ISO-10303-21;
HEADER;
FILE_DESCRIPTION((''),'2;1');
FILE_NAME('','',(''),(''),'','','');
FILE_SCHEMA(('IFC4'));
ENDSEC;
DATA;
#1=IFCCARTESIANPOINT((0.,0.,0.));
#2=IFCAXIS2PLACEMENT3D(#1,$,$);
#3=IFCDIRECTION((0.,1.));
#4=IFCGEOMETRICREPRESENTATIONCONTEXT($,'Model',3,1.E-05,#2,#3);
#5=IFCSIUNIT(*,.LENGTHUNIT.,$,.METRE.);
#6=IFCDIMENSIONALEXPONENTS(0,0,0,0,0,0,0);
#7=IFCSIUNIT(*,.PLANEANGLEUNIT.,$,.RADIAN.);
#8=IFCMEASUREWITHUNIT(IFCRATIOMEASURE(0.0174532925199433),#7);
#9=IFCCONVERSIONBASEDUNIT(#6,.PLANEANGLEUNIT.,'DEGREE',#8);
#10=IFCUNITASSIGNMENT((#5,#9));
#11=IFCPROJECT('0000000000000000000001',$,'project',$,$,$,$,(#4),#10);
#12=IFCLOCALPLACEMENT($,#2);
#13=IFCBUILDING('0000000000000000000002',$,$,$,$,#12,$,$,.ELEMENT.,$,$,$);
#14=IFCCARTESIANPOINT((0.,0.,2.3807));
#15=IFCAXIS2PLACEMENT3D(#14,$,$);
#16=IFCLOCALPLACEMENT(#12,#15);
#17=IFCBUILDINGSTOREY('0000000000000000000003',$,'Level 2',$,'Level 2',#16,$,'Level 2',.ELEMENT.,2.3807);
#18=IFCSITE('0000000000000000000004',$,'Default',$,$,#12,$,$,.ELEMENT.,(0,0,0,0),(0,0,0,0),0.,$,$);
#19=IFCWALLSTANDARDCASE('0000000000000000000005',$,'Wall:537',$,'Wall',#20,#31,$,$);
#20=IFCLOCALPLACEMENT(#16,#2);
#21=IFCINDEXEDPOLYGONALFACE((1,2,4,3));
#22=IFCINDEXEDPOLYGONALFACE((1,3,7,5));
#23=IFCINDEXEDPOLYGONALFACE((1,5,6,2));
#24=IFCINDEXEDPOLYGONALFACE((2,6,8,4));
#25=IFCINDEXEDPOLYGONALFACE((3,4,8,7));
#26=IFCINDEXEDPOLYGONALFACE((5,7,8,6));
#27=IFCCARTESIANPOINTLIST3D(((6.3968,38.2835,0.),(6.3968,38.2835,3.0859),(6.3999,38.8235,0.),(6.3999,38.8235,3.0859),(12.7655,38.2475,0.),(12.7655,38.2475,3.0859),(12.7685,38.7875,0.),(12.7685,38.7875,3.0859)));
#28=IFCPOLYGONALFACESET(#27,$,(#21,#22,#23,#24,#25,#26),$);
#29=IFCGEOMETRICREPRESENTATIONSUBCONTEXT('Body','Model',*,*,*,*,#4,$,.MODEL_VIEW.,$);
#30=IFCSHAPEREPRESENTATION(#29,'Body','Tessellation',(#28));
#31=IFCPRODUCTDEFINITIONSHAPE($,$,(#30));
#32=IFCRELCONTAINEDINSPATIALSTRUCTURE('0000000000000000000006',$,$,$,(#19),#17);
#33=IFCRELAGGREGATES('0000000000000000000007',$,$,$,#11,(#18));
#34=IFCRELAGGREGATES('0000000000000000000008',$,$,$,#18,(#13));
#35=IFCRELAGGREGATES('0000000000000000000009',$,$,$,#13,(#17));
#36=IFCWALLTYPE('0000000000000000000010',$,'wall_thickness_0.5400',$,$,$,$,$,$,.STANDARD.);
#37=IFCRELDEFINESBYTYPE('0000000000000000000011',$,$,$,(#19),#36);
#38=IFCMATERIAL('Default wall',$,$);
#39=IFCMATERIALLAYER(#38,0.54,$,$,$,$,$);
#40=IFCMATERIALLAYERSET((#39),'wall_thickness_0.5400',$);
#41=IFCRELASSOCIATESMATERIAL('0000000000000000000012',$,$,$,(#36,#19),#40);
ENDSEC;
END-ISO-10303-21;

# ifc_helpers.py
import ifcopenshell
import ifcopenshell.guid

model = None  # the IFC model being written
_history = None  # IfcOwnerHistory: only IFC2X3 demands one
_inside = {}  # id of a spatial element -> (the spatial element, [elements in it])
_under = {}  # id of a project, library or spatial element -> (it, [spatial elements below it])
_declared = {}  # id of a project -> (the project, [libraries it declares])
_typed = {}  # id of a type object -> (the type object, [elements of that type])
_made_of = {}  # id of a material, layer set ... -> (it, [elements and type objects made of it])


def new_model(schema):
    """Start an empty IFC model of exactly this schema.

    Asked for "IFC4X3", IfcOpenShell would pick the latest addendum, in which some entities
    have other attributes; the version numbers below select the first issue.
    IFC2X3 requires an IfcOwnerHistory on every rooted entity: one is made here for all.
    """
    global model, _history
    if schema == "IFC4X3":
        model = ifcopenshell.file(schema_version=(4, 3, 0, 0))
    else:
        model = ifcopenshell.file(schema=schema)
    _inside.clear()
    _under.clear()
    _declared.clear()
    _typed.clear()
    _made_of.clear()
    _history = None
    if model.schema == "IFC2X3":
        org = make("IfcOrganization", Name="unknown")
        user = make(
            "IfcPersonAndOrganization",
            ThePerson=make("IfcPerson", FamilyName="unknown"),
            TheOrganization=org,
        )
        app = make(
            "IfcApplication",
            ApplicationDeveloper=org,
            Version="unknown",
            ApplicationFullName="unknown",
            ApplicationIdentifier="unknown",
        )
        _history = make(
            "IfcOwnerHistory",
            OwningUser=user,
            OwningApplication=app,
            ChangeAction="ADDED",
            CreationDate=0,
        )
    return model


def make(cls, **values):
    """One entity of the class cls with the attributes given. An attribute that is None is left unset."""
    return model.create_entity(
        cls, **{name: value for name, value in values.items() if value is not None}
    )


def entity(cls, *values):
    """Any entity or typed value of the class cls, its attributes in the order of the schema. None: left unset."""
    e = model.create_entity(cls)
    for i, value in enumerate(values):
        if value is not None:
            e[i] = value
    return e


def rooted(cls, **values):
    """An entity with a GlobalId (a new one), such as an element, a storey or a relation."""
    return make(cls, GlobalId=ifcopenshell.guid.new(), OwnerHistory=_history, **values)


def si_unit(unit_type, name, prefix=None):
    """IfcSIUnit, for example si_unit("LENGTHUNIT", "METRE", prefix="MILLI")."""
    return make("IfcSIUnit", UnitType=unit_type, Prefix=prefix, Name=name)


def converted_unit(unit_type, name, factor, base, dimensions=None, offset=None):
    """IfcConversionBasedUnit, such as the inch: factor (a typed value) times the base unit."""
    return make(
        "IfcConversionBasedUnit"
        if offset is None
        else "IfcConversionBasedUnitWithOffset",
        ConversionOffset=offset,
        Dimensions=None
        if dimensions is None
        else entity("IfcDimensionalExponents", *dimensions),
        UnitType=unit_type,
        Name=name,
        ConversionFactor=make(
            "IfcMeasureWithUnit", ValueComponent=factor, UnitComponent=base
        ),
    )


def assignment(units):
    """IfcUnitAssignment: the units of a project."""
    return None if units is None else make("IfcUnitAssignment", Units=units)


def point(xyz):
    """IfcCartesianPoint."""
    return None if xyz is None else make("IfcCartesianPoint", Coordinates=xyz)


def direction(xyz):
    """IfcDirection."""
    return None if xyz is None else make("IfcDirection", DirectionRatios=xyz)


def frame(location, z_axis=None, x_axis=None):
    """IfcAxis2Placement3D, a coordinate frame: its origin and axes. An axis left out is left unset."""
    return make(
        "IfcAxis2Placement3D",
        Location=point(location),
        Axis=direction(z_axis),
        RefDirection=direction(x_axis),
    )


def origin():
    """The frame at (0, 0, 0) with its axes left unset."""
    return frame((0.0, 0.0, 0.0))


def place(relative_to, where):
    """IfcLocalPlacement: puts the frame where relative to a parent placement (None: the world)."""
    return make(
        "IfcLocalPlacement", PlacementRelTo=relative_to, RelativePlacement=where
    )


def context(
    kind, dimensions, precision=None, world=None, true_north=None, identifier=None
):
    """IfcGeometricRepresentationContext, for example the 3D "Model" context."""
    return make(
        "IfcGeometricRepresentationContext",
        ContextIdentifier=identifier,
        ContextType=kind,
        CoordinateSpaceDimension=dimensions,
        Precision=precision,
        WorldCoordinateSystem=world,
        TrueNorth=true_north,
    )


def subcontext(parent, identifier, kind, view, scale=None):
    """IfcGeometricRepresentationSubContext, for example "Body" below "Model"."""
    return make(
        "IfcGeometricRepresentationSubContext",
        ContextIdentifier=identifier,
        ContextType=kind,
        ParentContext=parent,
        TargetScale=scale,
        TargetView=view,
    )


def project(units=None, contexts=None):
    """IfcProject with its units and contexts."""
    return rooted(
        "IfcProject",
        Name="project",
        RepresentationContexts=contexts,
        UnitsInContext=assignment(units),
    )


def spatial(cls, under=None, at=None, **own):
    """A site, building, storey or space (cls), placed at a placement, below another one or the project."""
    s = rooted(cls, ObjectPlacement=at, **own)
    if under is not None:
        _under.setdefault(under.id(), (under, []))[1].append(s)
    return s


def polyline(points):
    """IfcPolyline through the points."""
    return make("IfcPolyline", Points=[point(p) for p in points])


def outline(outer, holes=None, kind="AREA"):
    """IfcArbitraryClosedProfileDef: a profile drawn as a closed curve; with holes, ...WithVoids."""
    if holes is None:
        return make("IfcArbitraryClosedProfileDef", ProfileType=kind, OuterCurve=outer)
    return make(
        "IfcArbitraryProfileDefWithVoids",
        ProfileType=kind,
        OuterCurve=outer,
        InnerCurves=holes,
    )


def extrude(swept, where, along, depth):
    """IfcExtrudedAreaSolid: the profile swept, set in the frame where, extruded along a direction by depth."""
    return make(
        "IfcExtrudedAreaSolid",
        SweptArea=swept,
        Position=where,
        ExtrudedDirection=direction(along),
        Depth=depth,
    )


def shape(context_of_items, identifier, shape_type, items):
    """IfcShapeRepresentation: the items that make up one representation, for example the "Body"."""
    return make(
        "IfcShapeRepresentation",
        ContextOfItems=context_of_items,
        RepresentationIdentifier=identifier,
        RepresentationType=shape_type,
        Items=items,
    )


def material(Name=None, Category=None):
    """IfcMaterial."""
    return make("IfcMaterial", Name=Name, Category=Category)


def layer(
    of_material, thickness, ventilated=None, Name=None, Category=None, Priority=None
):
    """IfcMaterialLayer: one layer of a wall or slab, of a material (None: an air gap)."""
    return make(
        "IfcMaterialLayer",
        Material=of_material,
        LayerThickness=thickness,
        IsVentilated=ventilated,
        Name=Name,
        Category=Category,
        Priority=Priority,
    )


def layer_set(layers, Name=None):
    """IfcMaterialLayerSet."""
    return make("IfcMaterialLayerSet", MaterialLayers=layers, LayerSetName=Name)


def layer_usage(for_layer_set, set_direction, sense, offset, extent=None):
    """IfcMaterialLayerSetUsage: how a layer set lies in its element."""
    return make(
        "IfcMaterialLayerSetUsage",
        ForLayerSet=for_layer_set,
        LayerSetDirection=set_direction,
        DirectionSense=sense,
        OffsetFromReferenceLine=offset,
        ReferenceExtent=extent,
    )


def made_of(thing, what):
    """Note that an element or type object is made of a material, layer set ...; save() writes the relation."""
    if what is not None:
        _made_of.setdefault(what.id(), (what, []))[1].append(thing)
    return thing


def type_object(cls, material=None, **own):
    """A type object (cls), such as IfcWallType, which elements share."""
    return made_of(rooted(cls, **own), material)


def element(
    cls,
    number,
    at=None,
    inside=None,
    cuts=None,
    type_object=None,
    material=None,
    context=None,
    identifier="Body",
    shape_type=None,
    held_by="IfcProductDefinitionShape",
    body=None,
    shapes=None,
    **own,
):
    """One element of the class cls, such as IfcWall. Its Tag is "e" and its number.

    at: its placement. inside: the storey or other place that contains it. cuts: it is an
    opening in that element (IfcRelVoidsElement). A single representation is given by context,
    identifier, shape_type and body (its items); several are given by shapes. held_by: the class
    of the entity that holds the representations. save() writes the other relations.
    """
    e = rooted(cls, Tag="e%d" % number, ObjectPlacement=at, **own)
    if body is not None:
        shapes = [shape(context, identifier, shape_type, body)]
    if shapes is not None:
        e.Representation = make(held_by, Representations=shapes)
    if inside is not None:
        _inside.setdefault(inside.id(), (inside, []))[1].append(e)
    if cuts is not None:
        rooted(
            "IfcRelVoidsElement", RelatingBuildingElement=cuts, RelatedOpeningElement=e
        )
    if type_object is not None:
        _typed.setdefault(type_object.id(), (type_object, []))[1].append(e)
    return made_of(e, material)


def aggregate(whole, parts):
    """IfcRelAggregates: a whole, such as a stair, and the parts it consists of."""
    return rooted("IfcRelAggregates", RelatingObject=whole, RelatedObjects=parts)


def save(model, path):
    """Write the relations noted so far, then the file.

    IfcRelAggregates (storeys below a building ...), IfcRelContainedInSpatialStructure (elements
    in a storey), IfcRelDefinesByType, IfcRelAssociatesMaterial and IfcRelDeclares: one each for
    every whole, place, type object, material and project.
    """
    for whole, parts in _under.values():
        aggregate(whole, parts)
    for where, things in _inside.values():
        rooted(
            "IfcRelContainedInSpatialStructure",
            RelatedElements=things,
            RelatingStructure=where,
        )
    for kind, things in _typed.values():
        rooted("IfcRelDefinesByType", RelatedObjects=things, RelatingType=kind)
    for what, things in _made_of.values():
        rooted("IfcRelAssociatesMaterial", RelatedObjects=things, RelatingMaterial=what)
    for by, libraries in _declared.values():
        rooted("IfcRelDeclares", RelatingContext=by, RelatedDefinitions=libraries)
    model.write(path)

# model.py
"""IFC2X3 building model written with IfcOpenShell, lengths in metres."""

from ifc_helpers import new_model, entity, si_unit, converted_unit, direction, frame, origin, place, context, subcontext, project, spatial, polyline, outline, extrude, material, layer, layer_set, layer_usage, type_object, element, save


model = new_model("IFC2X3")

# Units and contexts
model_context = context("Model", 3, precision=1e-05, world=origin(), true_north=direction((0.0, 1.0)))
body_context = subcontext(model_context, "Body", "Model", "MODEL_VIEW")
ifc_project = project(units=[si_unit("LENGTHUNIT", "METRE"), converted_unit("PLANEANGLEUNIT", "DEGREE", entity("IfcRatioMeasure", 0.0174532925199433), si_unit("PLANEANGLEUNIT", "RADIAN"), dimensions=[0, 0, 0, 0, 0, 0, 0])], contexts=[model_context])

# Site, building, storey
placement_1 = place(None, origin())
site = spatial("IfcSite", under=ifc_project, at=placement_1, Name="Default", CompositionType="ELEMENT", RefLatitude=(0, 0, 0, 0), RefLongitude=(0, 0, 0, 0), RefElevation=0.0)
building = spatial("IfcBuilding", under=site, at=placement_1, CompositionType="ELEMENT")
storey_placement = place(placement_1, frame((0.0, 0.0, 2.3807)))
storey = spatial("IfcBuildingStorey", under=building, at=storey_placement, Name="Level 2", ObjectType="Level 2", LongName="Level 2", CompositionType="ELEMENT", Elevation=2.3807)

# Shared definitions
ifc_material_1 = material(Name="Default wall")

# Wall
ifc_layer_1 = layer(ifc_material_1, 0.54)
ifc_layer_set_1 = layer_set([ifc_layer_1], Name="wall_thickness_0.5400")
ifc_layer_usage_1 = layer_usage(ifc_layer_set_1, "AXIS2", "POSITIVE", -0.27)
wall_type_1 = type_object("IfcWallType", Name="wall_thickness_0.5400", PredefinedType="STANDARD", material=ifc_layer_set_1)
wall_1_placement = place(storey_placement, frame((6.3983, 38.5535, 0.0), z_axis=(0.0, 0.0, 1.0), x_axis=(0.999984, -0.005658, 0.0)))
element("IfcWallStandardCase", 1, at=wall_1_placement, inside=storey, type_object=wall_type_1, material=ifc_layer_usage_1, Name="Wall:537", ObjectType="Wall", context=body_context, shape_type="SweptSolid", body=[
    extrude(outline(polyline([(6.3687, -0.27), (6.3687, 0.27), (0.0, 0.27), (0.0, -0.27), (6.3687, -0.27)])), origin(), (0.0, 0.0, 1.0), 3.0859),
])

save(model, "model.ifc")
